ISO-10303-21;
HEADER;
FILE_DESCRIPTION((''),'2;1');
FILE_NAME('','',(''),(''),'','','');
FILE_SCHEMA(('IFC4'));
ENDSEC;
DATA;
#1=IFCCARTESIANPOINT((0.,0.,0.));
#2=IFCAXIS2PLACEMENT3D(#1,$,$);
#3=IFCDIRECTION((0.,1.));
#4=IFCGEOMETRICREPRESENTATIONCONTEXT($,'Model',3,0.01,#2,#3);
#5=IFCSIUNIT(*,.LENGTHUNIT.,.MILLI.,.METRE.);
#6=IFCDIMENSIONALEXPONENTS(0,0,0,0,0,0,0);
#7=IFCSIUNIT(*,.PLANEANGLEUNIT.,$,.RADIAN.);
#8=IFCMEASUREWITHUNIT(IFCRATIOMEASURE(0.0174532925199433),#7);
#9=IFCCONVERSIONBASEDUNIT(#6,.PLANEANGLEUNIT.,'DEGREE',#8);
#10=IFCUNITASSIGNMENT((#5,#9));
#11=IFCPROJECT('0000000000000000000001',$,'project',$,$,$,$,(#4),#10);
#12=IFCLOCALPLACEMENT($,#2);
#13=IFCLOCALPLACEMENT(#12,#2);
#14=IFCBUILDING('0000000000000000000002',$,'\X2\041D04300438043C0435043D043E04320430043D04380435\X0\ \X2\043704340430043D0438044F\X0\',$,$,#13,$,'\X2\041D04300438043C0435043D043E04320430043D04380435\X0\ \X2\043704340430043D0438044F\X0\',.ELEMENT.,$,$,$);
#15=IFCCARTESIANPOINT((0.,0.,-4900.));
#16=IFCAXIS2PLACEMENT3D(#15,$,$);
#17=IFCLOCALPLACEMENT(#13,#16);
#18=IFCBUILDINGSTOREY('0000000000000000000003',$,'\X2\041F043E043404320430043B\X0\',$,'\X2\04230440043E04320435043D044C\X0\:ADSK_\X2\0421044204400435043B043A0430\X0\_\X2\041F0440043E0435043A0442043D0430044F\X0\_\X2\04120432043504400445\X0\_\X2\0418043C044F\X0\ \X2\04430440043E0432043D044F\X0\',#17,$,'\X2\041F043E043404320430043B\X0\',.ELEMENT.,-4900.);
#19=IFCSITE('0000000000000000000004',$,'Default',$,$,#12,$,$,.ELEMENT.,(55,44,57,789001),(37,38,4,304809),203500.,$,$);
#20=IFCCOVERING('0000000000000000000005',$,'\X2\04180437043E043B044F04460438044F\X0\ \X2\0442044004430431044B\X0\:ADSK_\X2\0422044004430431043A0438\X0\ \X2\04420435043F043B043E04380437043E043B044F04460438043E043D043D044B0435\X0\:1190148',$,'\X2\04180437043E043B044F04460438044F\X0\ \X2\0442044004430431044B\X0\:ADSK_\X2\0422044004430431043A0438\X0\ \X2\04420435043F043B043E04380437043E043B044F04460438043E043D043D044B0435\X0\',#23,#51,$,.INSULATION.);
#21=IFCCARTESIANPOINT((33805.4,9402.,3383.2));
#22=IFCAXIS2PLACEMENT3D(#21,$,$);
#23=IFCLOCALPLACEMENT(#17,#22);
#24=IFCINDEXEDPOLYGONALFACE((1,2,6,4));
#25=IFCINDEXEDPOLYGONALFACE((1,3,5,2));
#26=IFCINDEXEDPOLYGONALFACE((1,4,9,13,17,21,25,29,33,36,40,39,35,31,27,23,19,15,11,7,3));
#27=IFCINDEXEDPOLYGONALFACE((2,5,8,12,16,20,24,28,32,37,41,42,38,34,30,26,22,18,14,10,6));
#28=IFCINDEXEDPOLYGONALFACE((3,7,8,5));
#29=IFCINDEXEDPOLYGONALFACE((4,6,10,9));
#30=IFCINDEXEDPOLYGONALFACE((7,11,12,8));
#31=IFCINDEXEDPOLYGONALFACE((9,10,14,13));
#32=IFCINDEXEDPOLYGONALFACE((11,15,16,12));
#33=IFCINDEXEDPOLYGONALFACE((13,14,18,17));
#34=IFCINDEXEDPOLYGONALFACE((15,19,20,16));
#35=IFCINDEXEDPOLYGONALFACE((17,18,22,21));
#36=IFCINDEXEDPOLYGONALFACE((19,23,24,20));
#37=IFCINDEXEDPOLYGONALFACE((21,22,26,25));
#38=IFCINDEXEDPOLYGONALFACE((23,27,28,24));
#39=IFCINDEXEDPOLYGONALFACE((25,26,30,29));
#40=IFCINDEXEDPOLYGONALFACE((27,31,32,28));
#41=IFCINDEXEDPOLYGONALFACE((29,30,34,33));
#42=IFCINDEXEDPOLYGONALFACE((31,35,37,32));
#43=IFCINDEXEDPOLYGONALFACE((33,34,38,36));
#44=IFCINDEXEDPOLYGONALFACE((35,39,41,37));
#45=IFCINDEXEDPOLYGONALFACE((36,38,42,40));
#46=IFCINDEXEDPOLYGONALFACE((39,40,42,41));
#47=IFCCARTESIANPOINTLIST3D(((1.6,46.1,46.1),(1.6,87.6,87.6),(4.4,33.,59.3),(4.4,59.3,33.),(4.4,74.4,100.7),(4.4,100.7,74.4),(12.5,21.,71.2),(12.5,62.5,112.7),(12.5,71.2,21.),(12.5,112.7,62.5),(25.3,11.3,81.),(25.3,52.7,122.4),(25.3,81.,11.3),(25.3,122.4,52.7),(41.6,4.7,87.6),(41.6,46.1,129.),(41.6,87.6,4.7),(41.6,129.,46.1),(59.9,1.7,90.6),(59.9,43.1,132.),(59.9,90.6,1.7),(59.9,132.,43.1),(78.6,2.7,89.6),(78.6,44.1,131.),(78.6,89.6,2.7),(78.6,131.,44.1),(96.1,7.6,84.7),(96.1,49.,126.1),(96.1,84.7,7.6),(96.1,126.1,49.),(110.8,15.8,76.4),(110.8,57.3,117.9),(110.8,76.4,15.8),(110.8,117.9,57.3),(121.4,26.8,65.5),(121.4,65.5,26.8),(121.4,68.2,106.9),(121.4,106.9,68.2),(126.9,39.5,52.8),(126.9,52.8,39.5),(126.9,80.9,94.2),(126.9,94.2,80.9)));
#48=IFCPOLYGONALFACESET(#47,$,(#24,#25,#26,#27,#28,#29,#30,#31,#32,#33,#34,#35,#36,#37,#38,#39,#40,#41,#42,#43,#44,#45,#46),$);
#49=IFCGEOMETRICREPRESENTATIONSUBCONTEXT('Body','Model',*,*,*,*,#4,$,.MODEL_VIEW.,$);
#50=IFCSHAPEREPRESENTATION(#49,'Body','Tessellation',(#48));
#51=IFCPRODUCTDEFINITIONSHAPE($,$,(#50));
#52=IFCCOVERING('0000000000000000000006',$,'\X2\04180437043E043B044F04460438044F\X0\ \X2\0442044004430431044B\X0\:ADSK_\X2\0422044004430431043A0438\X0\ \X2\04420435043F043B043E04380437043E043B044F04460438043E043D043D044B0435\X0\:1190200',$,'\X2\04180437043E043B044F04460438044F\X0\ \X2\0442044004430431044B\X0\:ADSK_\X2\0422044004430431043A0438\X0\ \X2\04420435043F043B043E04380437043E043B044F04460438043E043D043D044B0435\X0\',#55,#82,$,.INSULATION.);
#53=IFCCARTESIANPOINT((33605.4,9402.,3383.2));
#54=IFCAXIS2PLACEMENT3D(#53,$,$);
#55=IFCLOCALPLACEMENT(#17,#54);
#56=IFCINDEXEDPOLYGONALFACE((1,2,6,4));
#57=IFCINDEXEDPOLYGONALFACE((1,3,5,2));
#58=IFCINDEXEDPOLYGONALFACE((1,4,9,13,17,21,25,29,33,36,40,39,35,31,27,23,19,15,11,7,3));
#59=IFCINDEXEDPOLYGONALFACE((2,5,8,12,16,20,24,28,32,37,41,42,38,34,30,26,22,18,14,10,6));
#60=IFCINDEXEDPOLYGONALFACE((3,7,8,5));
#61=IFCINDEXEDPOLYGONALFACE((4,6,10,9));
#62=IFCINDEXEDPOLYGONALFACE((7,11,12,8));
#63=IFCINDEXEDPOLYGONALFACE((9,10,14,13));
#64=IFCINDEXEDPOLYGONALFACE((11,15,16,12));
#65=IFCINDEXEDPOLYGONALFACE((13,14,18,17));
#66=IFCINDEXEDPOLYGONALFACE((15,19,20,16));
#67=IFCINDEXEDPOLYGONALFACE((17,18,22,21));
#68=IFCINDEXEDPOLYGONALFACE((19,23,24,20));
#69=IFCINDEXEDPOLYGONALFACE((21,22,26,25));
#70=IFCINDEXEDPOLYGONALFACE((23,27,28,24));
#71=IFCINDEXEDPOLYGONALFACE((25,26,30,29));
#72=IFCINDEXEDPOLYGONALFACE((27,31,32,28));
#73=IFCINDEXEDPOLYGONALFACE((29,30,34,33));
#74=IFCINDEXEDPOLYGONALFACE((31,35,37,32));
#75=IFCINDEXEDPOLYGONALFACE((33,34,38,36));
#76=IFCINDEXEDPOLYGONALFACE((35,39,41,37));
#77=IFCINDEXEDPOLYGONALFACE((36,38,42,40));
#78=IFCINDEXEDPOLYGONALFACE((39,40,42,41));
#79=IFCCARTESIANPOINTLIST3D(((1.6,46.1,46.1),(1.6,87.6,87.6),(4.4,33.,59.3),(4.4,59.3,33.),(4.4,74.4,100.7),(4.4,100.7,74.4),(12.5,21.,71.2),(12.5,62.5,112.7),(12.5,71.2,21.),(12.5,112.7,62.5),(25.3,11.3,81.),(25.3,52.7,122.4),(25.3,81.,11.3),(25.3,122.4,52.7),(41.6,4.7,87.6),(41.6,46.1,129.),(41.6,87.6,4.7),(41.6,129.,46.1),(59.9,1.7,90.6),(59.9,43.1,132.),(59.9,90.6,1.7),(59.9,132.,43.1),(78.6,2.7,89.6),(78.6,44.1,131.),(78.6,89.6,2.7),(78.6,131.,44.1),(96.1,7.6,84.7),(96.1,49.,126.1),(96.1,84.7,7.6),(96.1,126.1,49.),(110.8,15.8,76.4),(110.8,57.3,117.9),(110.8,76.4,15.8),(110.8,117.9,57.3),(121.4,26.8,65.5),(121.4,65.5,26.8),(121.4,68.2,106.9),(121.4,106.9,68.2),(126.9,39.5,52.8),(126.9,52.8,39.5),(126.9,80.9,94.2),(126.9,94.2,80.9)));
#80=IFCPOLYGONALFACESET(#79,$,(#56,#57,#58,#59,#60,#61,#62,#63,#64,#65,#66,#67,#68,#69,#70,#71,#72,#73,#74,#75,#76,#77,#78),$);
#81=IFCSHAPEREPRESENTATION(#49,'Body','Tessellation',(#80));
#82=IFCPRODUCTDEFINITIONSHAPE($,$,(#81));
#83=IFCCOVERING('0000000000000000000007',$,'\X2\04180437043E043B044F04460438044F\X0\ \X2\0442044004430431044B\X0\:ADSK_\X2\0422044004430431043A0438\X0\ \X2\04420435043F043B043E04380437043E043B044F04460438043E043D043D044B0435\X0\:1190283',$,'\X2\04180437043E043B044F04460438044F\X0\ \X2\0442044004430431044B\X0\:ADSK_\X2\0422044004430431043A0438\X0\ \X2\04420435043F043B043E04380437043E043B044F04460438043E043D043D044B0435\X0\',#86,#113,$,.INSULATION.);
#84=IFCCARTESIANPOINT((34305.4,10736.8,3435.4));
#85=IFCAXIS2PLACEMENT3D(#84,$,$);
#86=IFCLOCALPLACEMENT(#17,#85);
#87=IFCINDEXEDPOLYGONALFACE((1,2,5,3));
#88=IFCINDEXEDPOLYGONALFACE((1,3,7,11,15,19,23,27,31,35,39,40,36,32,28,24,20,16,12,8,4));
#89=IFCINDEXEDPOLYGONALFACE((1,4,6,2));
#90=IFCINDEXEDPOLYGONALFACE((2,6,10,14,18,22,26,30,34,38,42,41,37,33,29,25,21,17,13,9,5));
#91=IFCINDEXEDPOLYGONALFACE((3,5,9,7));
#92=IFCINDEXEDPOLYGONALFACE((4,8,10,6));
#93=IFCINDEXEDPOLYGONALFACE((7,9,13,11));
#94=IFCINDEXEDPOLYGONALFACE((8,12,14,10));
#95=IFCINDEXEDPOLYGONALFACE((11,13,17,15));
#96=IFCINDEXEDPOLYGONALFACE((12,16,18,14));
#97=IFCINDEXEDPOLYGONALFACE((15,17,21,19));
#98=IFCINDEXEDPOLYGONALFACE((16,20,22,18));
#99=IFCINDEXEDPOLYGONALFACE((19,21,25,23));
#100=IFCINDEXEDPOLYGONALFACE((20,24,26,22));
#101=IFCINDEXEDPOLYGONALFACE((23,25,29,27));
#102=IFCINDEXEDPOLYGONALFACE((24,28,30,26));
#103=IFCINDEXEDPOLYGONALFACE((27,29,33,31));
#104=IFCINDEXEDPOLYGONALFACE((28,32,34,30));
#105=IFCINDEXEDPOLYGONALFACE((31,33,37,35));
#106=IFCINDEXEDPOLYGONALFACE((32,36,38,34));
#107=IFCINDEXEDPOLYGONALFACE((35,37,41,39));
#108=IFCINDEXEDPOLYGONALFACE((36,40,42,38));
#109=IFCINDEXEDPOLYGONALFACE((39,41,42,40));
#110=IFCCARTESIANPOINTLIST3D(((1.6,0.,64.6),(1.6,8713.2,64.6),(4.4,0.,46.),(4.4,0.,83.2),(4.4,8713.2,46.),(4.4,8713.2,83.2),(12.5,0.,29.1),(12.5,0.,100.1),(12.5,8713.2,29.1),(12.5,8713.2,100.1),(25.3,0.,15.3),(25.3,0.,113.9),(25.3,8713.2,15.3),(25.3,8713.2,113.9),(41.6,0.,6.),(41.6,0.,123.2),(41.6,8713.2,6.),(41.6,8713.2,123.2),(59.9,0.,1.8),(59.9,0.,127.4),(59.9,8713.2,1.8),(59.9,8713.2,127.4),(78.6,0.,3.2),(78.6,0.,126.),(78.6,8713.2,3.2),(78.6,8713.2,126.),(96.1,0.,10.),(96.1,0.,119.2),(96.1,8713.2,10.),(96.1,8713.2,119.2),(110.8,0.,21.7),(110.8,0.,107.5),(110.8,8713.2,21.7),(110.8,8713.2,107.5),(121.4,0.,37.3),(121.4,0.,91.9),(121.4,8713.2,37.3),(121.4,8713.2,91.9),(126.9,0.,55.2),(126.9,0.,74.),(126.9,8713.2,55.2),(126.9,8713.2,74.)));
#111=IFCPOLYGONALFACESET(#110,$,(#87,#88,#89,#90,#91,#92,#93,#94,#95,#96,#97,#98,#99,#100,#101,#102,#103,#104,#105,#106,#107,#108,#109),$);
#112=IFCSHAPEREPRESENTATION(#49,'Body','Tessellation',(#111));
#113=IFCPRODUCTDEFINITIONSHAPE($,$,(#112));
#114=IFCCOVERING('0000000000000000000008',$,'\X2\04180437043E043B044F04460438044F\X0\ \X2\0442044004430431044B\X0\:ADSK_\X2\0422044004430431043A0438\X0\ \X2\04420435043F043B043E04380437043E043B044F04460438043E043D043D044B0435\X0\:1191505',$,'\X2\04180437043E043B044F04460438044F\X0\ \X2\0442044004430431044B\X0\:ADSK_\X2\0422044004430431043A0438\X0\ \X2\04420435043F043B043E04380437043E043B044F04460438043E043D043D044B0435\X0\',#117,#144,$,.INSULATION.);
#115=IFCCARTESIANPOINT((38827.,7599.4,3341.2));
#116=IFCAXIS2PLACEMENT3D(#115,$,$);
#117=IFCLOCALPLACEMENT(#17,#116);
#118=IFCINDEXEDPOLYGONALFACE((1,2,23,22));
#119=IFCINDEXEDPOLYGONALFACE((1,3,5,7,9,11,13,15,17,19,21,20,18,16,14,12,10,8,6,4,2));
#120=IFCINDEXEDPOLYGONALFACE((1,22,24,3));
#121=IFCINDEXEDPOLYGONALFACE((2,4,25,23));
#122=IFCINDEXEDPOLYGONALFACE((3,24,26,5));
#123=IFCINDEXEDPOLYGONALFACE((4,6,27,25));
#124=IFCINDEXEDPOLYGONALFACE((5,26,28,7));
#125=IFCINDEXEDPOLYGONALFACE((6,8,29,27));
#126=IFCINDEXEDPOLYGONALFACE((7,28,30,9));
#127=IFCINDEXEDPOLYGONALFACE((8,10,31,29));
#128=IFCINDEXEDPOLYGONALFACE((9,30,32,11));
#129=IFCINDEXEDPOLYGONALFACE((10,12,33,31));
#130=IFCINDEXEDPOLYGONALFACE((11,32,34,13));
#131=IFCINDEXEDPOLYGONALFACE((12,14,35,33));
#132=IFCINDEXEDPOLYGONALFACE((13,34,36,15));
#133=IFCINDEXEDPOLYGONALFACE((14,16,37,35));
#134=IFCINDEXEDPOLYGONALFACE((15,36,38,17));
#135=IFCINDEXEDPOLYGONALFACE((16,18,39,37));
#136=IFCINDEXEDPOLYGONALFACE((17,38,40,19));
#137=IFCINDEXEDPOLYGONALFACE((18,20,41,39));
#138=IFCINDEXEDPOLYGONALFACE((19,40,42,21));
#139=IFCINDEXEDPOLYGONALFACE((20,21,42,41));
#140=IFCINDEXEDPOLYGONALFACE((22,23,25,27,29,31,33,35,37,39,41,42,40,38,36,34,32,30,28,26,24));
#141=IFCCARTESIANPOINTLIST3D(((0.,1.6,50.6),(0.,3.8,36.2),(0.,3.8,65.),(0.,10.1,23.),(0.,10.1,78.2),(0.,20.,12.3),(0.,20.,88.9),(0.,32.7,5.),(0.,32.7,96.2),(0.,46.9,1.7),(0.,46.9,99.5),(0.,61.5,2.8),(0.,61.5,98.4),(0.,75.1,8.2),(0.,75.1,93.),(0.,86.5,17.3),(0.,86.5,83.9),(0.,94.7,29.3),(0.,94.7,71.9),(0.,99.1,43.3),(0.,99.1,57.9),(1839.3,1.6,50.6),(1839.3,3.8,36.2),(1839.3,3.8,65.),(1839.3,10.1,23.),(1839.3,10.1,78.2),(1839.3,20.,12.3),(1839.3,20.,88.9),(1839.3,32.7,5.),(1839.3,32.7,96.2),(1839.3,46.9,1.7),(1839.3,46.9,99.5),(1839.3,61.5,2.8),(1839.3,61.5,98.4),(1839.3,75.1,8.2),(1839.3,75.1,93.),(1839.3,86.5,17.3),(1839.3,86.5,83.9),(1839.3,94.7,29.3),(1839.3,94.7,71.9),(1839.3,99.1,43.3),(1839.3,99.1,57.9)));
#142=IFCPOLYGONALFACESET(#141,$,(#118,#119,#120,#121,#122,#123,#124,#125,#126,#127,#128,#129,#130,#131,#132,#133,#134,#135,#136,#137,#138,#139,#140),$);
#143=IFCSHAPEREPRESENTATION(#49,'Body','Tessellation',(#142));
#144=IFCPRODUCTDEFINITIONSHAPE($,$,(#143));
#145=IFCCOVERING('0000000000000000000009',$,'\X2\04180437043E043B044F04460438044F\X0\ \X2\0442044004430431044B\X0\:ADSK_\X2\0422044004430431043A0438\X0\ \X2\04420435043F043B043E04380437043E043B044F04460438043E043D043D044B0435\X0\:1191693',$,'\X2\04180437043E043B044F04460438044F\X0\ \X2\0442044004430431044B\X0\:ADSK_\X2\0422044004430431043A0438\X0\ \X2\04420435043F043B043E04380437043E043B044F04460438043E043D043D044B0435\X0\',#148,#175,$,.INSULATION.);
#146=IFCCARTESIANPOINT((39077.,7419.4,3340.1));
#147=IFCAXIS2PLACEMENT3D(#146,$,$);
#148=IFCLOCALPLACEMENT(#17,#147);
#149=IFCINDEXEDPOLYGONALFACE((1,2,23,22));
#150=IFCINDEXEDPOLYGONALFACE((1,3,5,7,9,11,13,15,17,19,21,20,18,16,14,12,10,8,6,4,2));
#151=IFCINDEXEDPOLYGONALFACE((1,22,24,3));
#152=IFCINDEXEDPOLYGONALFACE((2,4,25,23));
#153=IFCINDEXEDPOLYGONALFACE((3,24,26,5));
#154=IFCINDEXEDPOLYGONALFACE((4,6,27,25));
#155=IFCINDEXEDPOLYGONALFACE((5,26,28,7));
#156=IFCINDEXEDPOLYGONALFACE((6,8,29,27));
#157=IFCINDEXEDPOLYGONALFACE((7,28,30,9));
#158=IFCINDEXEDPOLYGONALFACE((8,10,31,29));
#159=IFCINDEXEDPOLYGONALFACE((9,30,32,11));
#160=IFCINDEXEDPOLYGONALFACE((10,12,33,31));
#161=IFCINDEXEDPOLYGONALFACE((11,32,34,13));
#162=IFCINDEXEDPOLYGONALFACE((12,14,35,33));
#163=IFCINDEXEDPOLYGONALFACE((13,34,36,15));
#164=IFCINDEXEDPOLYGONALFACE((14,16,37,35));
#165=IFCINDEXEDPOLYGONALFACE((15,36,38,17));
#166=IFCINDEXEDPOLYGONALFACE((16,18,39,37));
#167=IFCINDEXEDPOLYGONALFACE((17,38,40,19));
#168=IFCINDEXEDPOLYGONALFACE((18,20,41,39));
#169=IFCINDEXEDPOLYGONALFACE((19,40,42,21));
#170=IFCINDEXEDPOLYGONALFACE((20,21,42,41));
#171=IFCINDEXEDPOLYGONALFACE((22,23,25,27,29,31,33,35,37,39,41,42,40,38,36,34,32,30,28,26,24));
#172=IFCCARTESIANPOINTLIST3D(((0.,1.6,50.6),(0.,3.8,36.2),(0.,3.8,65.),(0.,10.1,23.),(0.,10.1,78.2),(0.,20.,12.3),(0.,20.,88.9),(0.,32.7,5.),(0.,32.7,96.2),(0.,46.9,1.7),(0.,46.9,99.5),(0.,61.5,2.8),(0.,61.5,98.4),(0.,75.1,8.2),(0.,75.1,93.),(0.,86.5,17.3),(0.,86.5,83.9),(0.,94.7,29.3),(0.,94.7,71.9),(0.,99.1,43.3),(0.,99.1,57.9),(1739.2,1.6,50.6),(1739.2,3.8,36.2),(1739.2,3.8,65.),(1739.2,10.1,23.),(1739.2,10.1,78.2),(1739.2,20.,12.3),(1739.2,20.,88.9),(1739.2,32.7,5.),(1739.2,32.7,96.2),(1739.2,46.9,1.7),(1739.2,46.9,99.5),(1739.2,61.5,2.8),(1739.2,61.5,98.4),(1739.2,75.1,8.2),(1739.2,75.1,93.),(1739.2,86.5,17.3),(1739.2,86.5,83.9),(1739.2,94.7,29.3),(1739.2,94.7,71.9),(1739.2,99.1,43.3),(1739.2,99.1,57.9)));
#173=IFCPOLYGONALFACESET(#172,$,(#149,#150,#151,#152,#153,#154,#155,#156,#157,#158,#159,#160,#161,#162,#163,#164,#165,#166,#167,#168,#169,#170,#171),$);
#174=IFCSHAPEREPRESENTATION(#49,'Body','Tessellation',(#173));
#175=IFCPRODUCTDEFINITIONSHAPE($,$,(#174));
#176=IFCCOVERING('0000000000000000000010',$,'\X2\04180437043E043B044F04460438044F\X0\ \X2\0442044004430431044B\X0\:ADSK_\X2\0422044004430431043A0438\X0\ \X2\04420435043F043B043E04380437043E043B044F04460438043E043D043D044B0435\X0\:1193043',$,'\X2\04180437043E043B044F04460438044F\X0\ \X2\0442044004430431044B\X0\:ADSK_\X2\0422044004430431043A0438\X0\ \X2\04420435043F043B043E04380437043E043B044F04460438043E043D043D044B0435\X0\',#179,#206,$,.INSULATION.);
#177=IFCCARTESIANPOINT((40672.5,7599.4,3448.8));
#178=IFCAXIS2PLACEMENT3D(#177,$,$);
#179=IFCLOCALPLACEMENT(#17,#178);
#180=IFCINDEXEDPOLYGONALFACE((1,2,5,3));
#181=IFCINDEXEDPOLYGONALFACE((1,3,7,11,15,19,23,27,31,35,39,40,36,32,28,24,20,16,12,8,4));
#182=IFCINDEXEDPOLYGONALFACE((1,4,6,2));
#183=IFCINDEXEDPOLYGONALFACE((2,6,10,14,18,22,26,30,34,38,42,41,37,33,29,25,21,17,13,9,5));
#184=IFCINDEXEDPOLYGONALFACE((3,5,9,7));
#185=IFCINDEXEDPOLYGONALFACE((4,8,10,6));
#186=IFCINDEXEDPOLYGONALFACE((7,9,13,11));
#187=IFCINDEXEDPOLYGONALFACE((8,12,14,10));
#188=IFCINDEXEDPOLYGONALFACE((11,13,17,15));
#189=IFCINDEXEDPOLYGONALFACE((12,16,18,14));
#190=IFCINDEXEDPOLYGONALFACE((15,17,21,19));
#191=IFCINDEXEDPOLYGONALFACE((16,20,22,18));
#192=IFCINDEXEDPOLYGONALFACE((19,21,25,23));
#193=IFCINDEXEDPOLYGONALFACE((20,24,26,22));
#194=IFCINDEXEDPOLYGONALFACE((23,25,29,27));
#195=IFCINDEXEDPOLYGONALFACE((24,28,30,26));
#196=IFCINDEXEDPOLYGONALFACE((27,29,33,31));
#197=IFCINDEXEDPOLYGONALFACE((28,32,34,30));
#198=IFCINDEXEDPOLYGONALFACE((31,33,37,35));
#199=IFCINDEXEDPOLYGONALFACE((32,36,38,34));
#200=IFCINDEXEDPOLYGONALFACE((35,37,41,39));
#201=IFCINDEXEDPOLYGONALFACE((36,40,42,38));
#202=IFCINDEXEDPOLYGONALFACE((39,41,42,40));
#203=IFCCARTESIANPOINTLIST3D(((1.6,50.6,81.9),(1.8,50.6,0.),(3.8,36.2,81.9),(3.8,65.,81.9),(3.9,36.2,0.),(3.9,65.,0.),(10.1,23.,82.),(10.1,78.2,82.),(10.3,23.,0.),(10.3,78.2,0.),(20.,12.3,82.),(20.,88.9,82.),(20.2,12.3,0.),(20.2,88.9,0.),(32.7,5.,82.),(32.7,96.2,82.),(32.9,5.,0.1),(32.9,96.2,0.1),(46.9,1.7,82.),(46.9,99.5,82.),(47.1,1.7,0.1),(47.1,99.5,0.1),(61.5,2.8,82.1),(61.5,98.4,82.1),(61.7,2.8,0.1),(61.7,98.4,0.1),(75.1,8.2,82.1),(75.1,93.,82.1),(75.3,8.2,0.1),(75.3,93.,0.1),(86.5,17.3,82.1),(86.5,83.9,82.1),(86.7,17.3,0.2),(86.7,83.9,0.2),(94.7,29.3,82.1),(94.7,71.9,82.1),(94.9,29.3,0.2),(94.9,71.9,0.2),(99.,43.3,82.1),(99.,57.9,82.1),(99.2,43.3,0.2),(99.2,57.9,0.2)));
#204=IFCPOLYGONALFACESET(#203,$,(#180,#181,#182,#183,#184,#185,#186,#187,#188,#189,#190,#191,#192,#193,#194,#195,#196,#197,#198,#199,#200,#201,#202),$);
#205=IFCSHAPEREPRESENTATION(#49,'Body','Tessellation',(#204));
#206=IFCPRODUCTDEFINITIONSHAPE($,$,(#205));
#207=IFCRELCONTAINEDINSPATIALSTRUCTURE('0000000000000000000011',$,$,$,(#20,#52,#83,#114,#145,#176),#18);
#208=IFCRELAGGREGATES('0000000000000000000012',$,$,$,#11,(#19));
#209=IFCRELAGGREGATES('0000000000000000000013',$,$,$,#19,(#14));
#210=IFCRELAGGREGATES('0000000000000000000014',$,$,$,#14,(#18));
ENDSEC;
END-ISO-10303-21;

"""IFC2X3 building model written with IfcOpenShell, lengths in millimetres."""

from ifc_helpers import new_model, entity, si_unit, converted_unit, direction, frame, origin, origin_2d_with_axis, place, context, subcontext, project, spatial, circle, extrude, element, save


model = new_model("IFC2X3")

# Units and contexts
model_context = context("Model", 3, precision=0.01, world=origin(), true_north=direction((0.0, 1.0)))
body_context = subcontext(model_context, "Body", "Model", "MODEL_VIEW")
ifc_project = project(units=[si_unit("LENGTHUNIT", "METRE", prefix="MILLI"), converted_unit("PLANEANGLEUNIT", "DEGREE", entity("IfcRatioMeasure", 0.0174532925199433), si_unit("PLANEANGLEUNIT", "RADIAN"), dimensions=[0, 0, 0, 0, 0, 0, 0])], contexts=[model_context])

# Site, building, storey
site_placement = place(None, origin())
site = spatial("IfcSite", under=ifc_project, at=site_placement, Name="Default", CompositionType="ELEMENT", RefLatitude=(55, 44, 57, 789001), RefLongitude=(37, 38, 4, 304809), RefElevation=203500.0)
building_placement = place(site_placement, origin())
building = spatial("IfcBuilding", under=site, at=building_placement, Name="Наименование здания", LongName="Наименование здания", CompositionType="ELEMENT")
storey_placement = place(building_placement, frame((0.0, 0.0, -4900.0)))
storey = spatial("IfcBuildingStorey", under=building, at=storey_placement, Name="Подвал", ObjectType="Уровень:ADSK_Стрелка_Проектная_Вверх_Имя уровня", LongName="Подвал", CompositionType="ELEMENT", Elevation=-4900.0)

# Coverings
covering_1_placement = place(storey_placement, frame((33805.4, 9402.0, 3383.2)))
element("IfcCovering", 1, at=covering_1_placement, inside=storey, Name="Изоляция трубы:ADSK_Трубки теплоизоляционные:1190148", ObjectType="Изоляция трубы:ADSK_Трубки теплоизоляционные", PredefinedType="INSULATION", context=body_context, shape_type="SweptSolid", body=[
    extrude(circle(Radius=63.0, at=origin_2d_with_axis()), frame((64.6, 46.1, 46.1), z_axis=(0.0, 0.707107, 0.707107), x_axis=(-1.0, 0.0, 0.0)), (0.0, 0.0, 1.0), 58.6),
])
covering_2_placement = place(storey_placement, frame((33605.4, 9402.0, 3383.2)))
element("IfcCovering", 2, at=covering_2_placement, inside=storey, Name="Изоляция трубы:ADSK_Трубки теплоизоляционные:1190200", ObjectType="Изоляция трубы:ADSK_Трубки теплоизоляционные", PredefinedType="INSULATION", context=body_context, shape_type="SweptSolid", body=[
    extrude(circle(Radius=63.0, at=origin_2d_with_axis()), frame((64.6, 46.1, 46.1), z_axis=(0.0, 0.707107, 0.707107), x_axis=(-1.0, 0.0, 0.0)), (0.0, 0.0, 1.0), 58.6),
])
covering_3_placement = place(storey_placement, frame((34305.4, 10736.8, 3435.4)))
element("IfcCovering", 3, at=covering_3_placement, inside=storey, Name="Изоляция трубы:ADSK_Трубки теплоизоляционные:1190283", ObjectType="Изоляция трубы:ADSK_Трубки теплоизоляционные", PredefinedType="INSULATION", context=body_context, shape_type="SweptSolid", body=[
    extrude(circle(Radius=63.0, at=origin_2d_with_axis()), frame((64.6, 0.0, 64.6), z_axis=(0.0, 1.0, 0.0), x_axis=(-1.0, 0.0, 0.0)), (0.0, 0.0, 1.0), 8713.2),
])
covering_4_placement = place(storey_placement, frame((38827.0, 7599.4, 3341.2)))
element("IfcCovering", 4, at=covering_4_placement, inside=storey, Name="Изоляция трубы:ADSK_Трубки теплоизоляционные:1191505", ObjectType="Изоляция трубы:ADSK_Трубки теплоизоляционные", PredefinedType="INSULATION", context=body_context, shape_type="SweptSolid", body=[
    extrude(circle(Radius=49.0, at=origin_2d_with_axis()), frame((0.0, 50.6, 50.6), z_axis=(1.0, 0.0, 0.0), x_axis=(0.0, -1.0, 0.0)), (0.0, 0.0, 1.0), 1839.3),
])
covering_5_placement = place(storey_placement, frame((39077.0, 7419.4, 3340.1)))
element("IfcCovering", 5, at=covering_5_placement, inside=storey, Name="Изоляция трубы:ADSK_Трубки теплоизоляционные:1191693", ObjectType="Изоляция трубы:ADSK_Трубки теплоизоляционные", PredefinedType="INSULATION", context=body_context, shape_type="SweptSolid", body=[
    extrude(circle(Radius=49.0, at=origin_2d_with_axis()), frame((0.0, 50.6, 50.6), z_axis=(1.0, 0.0, 0.0), x_axis=(0.0, -1.0, 0.0)), (0.0, 0.0, 1.0), 1739.2),
])
covering_6_placement = place(storey_placement, frame((40672.5, 7599.4, 3448.8)))
element("IfcCovering", 6, at=covering_6_placement, inside=storey, Name="Изоляция трубы:ADSK_Трубки теплоизоляционные:1193043", ObjectType="Изоляция трубы:ADSK_Трубки теплоизоляционные", PredefinedType="INSULATION", context=body_context, shape_type="SweptSolid", body=[
    extrude(circle(Radius=49.0, at=origin_2d_with_axis()), frame((50.8, 50.6, 0.1), z_axis=(-0.001995, 0.0, 0.999998), x_axis=(-0.999998, 0.0, -0.001995)), (0.0, 0.0, 1.0), 81.9),
])

save(model, "model.ifc")
